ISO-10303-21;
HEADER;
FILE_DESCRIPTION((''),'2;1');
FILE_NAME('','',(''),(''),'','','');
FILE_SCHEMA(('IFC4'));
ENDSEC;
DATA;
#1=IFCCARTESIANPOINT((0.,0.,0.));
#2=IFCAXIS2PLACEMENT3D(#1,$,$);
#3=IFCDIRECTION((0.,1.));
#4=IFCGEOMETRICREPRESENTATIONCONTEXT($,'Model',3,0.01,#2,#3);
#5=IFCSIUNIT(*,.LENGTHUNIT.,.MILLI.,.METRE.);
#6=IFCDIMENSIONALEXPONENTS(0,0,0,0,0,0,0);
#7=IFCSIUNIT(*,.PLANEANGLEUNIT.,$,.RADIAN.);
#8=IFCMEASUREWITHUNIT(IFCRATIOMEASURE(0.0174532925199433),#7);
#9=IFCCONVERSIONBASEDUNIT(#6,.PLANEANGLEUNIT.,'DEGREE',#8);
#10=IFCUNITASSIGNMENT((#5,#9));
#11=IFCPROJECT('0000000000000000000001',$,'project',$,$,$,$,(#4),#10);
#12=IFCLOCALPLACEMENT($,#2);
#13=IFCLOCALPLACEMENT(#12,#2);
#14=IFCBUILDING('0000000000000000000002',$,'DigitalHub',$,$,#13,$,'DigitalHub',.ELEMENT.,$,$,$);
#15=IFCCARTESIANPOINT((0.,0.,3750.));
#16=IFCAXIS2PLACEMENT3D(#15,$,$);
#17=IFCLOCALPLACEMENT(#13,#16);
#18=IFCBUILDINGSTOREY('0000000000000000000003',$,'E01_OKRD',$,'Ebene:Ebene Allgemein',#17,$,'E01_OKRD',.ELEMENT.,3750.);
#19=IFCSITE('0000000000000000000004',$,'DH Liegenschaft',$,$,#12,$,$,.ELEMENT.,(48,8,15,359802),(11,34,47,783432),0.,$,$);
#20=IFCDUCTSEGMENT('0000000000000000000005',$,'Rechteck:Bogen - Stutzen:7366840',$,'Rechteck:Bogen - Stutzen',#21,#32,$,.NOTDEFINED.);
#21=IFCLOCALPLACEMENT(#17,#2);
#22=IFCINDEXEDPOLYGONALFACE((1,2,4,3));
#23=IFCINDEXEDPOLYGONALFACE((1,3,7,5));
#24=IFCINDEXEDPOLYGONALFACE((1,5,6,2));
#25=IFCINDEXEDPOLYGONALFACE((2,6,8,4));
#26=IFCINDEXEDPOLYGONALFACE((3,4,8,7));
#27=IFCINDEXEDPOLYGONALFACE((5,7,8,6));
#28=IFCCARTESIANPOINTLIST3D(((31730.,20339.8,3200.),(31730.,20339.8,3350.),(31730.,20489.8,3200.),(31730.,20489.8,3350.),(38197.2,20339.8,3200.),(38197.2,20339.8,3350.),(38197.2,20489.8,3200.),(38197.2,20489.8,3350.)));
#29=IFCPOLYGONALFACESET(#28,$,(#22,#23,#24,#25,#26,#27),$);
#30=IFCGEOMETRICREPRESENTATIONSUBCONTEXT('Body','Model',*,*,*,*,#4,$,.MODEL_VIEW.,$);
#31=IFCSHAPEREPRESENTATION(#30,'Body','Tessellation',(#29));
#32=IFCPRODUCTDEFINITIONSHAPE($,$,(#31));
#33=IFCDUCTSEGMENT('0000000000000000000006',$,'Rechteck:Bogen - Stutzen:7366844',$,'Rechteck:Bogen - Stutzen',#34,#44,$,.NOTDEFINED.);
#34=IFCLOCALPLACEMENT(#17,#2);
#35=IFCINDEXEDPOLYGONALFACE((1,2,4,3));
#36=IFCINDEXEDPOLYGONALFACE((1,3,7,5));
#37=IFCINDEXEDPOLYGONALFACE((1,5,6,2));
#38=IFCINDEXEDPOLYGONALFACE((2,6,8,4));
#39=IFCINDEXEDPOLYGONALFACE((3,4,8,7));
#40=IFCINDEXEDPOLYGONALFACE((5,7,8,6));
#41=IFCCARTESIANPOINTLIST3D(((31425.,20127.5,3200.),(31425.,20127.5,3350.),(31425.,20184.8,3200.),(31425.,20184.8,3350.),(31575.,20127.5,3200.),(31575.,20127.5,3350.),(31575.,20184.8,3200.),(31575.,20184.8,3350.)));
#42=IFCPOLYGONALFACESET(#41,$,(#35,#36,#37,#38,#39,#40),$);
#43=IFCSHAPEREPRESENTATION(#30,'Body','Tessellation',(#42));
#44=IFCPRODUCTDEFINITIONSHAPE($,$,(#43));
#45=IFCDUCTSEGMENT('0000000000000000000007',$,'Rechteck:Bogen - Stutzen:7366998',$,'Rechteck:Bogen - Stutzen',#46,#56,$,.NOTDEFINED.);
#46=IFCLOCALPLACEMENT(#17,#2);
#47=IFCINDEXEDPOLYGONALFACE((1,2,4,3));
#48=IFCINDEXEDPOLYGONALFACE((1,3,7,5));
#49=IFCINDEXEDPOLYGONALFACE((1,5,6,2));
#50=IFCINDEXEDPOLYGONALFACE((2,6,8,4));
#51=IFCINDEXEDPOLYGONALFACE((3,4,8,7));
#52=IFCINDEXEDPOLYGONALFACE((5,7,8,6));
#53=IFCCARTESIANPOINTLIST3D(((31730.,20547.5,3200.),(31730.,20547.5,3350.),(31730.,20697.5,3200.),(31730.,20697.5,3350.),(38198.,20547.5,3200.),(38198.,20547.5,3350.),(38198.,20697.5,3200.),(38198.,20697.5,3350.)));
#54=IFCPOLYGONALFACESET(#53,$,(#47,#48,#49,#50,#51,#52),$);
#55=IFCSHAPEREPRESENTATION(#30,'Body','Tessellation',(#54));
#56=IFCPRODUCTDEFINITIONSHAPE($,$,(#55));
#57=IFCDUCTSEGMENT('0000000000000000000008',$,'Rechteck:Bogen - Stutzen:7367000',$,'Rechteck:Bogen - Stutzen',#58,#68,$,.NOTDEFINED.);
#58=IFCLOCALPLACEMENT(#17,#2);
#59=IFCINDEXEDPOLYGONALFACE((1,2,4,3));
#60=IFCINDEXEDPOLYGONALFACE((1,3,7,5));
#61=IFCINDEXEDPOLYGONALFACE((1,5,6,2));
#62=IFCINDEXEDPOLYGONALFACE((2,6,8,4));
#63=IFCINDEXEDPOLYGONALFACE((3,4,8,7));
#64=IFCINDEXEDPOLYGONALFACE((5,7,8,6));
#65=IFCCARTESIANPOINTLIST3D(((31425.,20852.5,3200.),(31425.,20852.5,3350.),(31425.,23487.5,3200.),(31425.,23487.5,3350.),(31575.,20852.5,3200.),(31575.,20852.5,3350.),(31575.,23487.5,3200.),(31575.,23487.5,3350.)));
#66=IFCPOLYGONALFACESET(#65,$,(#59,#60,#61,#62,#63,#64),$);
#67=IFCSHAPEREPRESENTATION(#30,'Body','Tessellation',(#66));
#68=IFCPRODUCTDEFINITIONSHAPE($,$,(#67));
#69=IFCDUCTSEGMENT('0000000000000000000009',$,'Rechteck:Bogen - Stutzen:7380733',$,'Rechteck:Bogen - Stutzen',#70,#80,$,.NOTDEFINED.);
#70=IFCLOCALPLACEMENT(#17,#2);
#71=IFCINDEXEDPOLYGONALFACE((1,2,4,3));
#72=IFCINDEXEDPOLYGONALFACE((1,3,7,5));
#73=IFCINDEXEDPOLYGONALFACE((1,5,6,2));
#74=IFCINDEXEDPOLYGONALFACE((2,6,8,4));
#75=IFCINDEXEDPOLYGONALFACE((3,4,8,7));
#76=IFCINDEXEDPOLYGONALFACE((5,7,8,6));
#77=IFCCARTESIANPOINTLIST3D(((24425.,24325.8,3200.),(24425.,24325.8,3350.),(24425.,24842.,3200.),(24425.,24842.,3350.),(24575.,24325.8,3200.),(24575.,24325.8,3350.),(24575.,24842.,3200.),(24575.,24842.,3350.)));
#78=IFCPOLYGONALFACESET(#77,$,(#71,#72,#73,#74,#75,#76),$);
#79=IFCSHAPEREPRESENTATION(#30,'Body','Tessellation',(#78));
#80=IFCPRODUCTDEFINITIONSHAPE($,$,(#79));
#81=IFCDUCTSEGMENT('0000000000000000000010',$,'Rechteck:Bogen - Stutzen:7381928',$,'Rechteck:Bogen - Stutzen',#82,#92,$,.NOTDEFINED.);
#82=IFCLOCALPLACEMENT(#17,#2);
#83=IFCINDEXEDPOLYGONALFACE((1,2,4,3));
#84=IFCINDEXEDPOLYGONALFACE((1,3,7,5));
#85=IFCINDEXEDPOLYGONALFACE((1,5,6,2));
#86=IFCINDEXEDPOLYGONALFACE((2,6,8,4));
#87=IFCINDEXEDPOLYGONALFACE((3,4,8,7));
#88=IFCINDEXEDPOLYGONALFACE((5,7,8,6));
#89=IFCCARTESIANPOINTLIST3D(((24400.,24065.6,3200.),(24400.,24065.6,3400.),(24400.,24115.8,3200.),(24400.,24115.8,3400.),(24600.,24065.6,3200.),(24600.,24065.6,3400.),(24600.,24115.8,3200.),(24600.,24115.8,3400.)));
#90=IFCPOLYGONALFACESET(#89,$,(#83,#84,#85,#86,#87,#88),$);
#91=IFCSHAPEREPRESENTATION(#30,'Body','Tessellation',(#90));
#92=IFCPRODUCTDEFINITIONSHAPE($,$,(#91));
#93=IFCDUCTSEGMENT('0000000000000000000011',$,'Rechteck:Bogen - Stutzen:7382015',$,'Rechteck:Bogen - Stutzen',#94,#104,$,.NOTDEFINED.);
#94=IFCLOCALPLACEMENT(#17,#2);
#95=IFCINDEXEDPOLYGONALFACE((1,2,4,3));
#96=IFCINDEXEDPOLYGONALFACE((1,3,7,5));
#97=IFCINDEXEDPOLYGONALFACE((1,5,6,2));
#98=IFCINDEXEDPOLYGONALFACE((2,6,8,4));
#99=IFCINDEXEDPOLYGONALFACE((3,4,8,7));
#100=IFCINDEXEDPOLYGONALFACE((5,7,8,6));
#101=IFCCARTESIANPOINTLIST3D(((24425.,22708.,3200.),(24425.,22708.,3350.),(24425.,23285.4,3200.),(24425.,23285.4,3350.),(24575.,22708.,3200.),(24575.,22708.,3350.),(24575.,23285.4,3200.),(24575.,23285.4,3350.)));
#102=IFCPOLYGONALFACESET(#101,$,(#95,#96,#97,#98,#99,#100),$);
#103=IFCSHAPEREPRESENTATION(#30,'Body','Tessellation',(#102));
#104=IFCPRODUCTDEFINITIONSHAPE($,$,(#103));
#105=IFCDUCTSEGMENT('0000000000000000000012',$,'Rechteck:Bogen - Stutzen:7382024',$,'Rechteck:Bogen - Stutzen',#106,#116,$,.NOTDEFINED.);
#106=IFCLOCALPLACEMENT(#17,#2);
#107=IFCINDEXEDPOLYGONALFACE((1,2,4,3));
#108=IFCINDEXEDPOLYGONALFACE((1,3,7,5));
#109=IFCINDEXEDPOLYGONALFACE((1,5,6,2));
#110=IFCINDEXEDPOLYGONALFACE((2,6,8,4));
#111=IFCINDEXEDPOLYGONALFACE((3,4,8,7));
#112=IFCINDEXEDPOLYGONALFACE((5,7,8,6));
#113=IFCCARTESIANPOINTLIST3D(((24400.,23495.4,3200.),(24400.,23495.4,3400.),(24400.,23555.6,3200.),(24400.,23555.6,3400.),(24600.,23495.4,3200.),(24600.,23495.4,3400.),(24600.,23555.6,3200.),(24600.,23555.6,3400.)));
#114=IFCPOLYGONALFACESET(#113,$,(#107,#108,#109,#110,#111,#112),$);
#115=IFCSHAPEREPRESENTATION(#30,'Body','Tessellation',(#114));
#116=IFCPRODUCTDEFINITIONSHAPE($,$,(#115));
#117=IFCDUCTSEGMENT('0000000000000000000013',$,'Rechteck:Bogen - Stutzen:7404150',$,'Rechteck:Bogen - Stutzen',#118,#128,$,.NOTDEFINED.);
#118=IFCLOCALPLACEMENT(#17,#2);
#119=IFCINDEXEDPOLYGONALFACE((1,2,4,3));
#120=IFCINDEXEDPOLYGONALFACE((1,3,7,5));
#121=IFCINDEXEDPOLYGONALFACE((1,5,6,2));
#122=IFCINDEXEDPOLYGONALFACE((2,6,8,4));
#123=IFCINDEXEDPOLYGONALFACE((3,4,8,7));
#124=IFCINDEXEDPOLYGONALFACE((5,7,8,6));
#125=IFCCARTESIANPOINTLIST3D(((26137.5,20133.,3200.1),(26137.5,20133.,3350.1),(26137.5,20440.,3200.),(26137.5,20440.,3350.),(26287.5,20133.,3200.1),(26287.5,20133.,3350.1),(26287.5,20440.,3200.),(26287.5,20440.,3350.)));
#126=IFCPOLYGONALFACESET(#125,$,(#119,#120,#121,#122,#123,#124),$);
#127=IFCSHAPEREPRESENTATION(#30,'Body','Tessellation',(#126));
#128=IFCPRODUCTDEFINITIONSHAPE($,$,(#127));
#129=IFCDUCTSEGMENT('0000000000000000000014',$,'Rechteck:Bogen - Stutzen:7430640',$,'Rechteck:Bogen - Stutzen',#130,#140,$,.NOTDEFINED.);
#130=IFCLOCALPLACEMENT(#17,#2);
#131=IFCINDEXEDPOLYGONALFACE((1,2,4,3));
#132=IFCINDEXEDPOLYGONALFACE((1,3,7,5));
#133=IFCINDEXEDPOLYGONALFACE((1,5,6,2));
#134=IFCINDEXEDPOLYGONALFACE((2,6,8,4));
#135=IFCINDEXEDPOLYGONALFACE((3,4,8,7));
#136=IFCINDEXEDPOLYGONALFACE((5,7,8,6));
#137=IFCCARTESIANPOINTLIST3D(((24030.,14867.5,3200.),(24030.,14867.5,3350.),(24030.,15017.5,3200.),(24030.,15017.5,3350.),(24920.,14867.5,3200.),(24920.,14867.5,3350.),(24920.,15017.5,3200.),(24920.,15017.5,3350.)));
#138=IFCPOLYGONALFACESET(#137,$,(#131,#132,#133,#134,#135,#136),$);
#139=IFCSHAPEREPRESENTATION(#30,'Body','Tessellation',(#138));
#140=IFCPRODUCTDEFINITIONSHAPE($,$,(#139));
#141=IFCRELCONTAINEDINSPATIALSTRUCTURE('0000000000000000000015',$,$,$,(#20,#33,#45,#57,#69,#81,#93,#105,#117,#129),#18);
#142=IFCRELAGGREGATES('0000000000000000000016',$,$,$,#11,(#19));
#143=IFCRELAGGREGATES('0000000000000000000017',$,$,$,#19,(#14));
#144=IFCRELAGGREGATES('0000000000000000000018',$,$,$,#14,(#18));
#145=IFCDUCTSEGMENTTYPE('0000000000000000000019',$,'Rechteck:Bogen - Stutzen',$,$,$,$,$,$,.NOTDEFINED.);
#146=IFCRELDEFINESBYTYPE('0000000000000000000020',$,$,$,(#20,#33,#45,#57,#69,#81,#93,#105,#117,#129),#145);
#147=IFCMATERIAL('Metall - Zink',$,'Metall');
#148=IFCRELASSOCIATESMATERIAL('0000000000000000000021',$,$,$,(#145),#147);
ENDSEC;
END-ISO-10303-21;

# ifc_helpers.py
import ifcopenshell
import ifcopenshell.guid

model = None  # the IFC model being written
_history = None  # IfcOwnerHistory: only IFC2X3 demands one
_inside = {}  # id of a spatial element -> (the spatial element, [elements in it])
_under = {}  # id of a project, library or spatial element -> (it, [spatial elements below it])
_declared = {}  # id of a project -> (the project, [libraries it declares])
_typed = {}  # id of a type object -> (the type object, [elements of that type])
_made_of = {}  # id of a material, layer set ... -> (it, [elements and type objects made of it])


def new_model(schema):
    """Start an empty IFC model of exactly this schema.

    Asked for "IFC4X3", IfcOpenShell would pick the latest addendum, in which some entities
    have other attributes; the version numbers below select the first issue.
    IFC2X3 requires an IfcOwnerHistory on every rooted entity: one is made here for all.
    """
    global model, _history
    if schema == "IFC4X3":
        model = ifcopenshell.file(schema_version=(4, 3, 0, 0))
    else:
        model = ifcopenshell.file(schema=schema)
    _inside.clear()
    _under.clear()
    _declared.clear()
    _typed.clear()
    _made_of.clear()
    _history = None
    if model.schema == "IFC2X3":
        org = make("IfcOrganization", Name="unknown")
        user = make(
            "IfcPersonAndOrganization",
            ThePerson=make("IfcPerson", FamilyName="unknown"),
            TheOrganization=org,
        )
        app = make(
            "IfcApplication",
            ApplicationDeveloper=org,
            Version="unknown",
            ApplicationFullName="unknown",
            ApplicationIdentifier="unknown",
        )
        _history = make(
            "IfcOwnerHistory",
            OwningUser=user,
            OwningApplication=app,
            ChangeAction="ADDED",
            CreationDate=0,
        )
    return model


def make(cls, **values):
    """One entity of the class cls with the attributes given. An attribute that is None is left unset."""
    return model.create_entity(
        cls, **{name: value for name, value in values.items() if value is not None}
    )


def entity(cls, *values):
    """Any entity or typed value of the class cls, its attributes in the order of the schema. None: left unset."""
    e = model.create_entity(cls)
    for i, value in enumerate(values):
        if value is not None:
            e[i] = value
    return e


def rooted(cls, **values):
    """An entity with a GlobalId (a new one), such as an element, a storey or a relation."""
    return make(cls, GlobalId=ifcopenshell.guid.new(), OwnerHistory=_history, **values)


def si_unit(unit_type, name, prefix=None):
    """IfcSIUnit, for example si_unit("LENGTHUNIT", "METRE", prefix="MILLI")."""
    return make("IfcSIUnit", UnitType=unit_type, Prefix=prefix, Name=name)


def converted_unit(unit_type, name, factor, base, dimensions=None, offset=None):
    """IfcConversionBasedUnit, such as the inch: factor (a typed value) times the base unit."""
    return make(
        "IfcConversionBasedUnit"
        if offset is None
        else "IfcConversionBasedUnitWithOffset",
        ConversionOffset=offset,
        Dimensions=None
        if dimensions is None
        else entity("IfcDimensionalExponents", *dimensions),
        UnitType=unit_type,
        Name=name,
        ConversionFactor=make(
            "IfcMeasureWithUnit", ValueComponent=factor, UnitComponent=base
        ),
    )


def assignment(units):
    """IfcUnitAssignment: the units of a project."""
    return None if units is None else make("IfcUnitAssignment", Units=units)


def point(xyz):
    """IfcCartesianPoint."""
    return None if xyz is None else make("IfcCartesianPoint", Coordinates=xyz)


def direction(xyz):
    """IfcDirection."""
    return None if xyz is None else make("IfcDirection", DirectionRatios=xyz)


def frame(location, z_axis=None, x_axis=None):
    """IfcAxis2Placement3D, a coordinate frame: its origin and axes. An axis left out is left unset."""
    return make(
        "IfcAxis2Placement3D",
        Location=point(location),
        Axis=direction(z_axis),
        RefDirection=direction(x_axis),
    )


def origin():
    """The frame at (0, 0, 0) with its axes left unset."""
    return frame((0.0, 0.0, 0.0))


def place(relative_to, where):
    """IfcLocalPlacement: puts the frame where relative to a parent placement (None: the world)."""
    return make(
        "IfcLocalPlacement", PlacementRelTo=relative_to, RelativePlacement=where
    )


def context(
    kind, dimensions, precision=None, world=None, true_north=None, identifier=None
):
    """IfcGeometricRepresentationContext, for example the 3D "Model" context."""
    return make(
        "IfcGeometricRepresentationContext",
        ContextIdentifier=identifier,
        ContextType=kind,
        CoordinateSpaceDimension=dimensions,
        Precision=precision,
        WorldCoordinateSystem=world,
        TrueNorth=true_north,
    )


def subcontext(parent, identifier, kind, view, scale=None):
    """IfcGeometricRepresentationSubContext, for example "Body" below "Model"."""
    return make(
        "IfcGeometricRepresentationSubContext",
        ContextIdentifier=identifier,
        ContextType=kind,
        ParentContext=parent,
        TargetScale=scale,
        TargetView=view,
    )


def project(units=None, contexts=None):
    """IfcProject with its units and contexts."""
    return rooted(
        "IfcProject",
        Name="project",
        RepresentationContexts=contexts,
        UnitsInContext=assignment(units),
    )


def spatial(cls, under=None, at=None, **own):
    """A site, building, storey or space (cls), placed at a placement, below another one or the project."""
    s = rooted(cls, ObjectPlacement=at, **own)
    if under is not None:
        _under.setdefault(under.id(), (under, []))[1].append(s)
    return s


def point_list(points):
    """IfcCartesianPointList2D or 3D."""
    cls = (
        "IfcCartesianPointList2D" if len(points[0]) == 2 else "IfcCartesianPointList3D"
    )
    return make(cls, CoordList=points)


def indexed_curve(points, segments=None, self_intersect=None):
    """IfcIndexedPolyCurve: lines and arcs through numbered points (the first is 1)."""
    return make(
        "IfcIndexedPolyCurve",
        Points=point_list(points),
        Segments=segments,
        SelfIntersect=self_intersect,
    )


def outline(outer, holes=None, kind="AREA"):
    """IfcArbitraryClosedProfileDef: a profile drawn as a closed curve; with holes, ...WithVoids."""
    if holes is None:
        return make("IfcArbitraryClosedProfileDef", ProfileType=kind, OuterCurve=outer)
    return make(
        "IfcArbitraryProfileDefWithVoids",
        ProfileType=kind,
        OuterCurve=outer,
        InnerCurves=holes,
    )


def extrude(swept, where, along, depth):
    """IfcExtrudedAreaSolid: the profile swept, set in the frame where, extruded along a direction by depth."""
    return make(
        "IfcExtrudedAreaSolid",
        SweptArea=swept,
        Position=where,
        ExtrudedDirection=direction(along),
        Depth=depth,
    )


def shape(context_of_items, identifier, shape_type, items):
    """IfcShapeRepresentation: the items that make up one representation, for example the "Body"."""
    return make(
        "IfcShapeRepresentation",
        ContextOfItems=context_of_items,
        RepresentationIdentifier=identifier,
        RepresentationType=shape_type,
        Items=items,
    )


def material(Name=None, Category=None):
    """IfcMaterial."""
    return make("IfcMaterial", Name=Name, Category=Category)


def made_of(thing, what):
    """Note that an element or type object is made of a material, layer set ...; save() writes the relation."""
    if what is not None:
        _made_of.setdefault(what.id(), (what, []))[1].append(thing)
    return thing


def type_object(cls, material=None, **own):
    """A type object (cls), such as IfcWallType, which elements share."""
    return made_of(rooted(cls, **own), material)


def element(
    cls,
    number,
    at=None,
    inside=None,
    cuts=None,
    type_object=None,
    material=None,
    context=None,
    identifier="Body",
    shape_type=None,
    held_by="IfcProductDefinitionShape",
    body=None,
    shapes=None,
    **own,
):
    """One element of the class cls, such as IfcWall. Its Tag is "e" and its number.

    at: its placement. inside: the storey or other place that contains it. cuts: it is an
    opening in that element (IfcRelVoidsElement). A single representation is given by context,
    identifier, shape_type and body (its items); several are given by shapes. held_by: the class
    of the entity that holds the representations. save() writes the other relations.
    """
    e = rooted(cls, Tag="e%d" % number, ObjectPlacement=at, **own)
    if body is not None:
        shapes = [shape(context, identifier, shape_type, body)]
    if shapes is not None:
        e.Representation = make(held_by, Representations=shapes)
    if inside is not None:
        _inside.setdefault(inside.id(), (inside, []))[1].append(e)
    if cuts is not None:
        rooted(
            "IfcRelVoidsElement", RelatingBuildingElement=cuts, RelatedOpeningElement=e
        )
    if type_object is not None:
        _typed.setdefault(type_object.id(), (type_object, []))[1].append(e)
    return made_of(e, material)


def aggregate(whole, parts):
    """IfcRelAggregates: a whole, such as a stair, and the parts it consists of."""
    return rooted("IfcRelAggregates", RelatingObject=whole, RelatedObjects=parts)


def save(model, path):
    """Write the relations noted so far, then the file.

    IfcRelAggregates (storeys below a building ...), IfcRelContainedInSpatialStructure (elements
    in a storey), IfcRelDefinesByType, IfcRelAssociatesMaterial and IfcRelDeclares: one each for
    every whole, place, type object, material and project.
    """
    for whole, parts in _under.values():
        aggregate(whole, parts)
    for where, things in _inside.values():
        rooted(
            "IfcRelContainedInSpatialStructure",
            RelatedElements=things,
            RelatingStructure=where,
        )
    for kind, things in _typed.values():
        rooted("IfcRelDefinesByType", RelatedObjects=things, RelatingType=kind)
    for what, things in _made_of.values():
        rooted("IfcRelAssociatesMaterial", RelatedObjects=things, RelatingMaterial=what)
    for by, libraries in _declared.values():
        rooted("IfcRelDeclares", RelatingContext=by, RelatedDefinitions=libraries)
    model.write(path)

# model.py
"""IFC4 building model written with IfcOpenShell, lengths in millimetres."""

from ifc_helpers import new_model, entity, si_unit, converted_unit, direction, frame, origin, place, context, subcontext, project, spatial, indexed_curve, outline, extrude, material, type_object, element, save


model = new_model("IFC4")

# Units and contexts
model_context = context("Model", 3, precision=0.01, world=origin(), true_north=direction((0.0, 1.0)))
body_context = subcontext(model_context, "Body", "Model", "MODEL_VIEW")
ifc_project = project(units=[si_unit("LENGTHUNIT", "METRE", prefix="MILLI"), converted_unit("PLANEANGLEUNIT", "DEGREE", entity("IfcRatioMeasure", 0.0174532925199433), si_unit("PLANEANGLEUNIT", "RADIAN"), dimensions=[0, 0, 0, 0, 0, 0, 0])], contexts=[model_context])

# Site, building, storey
site_placement = place(None, origin())
site = spatial("IfcSite", under=ifc_project, at=site_placement, Name="DH Liegenschaft", CompositionType="ELEMENT", RefLatitude=(48, 8, 15, 359802), RefLongitude=(11, 34, 47, 783432), RefElevation=0.0)
building_placement = place(site_placement, origin())
building = spatial("IfcBuilding", under=site, at=building_placement, Name="DigitalHub", LongName="DigitalHub", CompositionType="ELEMENT")
storey_placement = place(building_placement, frame((0.0, 0.0, 3750.0)))
storey = spatial("IfcBuildingStorey", under=building, at=storey_placement, Name="E01_OKRD", ObjectType="Ebene:Ebene Allgemein", LongName="E01_OKRD", CompositionType="ELEMENT", Elevation=3750.0)

# Duct segments
ifc_material_1 = material(Name="Metall - Zink", Category="Metall")
duct_segment_type_1 = type_object("IfcDuctSegmentType", Name="Rechteck:Bogen - Stutzen", PredefinedType="NOTDEFINED", material=ifc_material_1)
duct_segment_1_placement = place(storey_placement, frame((31730.0, 20339.8, 3200.0)))
element("IfcDuctSegment", 1, at=duct_segment_1_placement, inside=storey, type_object=duct_segment_type_1, Name="Rechteck:Bogen - Stutzen:7366840", ObjectType="Rechteck:Bogen - Stutzen", PredefinedType="NOTDEFINED", context=body_context, shape_type="SweptSolid", body=[
    extrude(outline(indexed_curve([(-3233.6, -75.0), (3233.6, -75.0), (3233.6, 75.0), (-3233.6, 75.0), (-3233.6, -75.0)], self_intersect=False)), frame((3233.6, 75.0, 0.0)), (0.0, 0.0, 1.0), 150.0),
])
duct_segment_2_placement = place(storey_placement, frame((31425.0, 20127.5, 3200.0)))
element("IfcDuctSegment", 2, at=duct_segment_2_placement, inside=storey, type_object=duct_segment_type_1, Name="Rechteck:Bogen - Stutzen:7366844", ObjectType="Rechteck:Bogen - Stutzen", PredefinedType="NOTDEFINED", context=body_context, shape_type="SweptSolid", body=[
    extrude(outline(indexed_curve([(-28.7, -75.0), (28.7, -75.0), (28.7, 75.0), (-28.7, 75.0), (-28.7, -75.0)], self_intersect=False)), frame((75.0, 28.7, 0.0), z_axis=(0.0, 0.0, 1.0), x_axis=(0.0, 1.0, 0.0)), (0.0, 0.0, 1.0), 150.0),
])
duct_segment_3_placement = place(storey_placement, frame((31730.0, 20547.5, 3200.0)))
element("IfcDuctSegment", 3, at=duct_segment_3_placement, inside=storey, type_object=duct_segment_type_1, Name="Rechteck:Bogen - Stutzen:7366998", ObjectType="Rechteck:Bogen - Stutzen", PredefinedType="NOTDEFINED", context=body_context, shape_type="SweptSolid", body=[
    extrude(outline(indexed_curve([(-3234.0, -75.0), (3234.0, -75.0), (3234.0, 75.0), (-3234.0, 75.0), (-3234.0, -75.0)], self_intersect=False)), frame((3234.0, 75.0, 0.0), z_axis=(0.0, 0.0, 1.0), x_axis=(-1.0, 0.0, 0.0)), (0.0, 0.0, 1.0), 150.0),
])
duct_segment_4_placement = place(storey_placement, frame((31425.0, 20852.5, 3200.0)))
element("IfcDuctSegment", 4, at=duct_segment_4_placement, inside=storey, type_object=duct_segment_type_1, Name="Rechteck:Bogen - Stutzen:7367000", ObjectType="Rechteck:Bogen - Stutzen", PredefinedType="NOTDEFINED", context=body_context, shape_type="SweptSolid", body=[
    extrude(outline(indexed_curve([(-1317.5, -75.0), (1317.5, -75.0), (1317.5, 75.0), (-1317.5, 75.0), (-1317.5, -75.0)], self_intersect=False)), frame((75.0, 1317.5, 0.0), z_axis=(0.0, 0.0, 1.0), x_axis=(0.0, 1.0, 0.0)), (0.0, 0.0, 1.0), 150.0),
])
duct_segment_5_placement = place(storey_placement, frame((24425.0, 24325.8, 3200.0)))
element("IfcDuctSegment", 5, at=duct_segment_5_placement, inside=storey, type_object=duct_segment_type_1, Name="Rechteck:Bogen - Stutzen:7380733", ObjectType="Rechteck:Bogen - Stutzen", PredefinedType="NOTDEFINED", context=body_context, shape_type="SweptSolid", body=[
    extrude(outline(indexed_curve([(-258.1, -75.0), (258.1, -75.0), (258.1, 75.0), (-258.1, 75.0), (-258.1, -75.0)], self_intersect=False)), frame((75.0, 258.1, 0.0), z_axis=(0.0, 0.0, 1.0), x_axis=(0.0, -1.0, 0.0)), (0.0, 0.0, 1.0), 150.0),
])
duct_segment_6_placement = place(storey_placement, frame((24400.0, 24065.6, 3200.0)))
element("IfcDuctSegment", 6, at=duct_segment_6_placement, inside=storey, type_object=duct_segment_type_1, Name="Rechteck:Bogen - Stutzen:7381928", ObjectType="Rechteck:Bogen - Stutzen", PredefinedType="NOTDEFINED", context=body_context, shape_type="SweptSolid", body=[
    extrude(outline(indexed_curve([(-25.1, -100.0), (25.1, -100.0), (25.1, 100.0), (-25.1, 100.0), (-25.1, -100.0)], self_intersect=False)), frame((100.0, 25.1, 0.0), z_axis=(0.0, 0.0, 1.0), x_axis=(0.0, 1.0, 0.0)), (0.0, 0.0, 1.0), 200.0),
])
duct_segment_7_placement = place(storey_placement, frame((24425.0, 22708.0, 3200.0)))
element("IfcDuctSegment", 7, at=duct_segment_7_placement, inside=storey, type_object=duct_segment_type_1, Name="Rechteck:Bogen - Stutzen:7382015", ObjectType="Rechteck:Bogen - Stutzen", PredefinedType="NOTDEFINED", context=body_context, shape_type="SweptSolid", body=[
    extrude(outline(indexed_curve([(-288.7, -75.0), (288.7, -75.0), (288.7, 75.0), (-288.7, 75.0), (-288.7, -75.0)], self_intersect=False)), frame((75.0, 288.7, 0.0), z_axis=(0.0, 0.0, 1.0), x_axis=(0.0, -1.0, 0.0)), (0.0, 0.0, 1.0), 150.0),
])
duct_segment_8_placement = place(storey_placement, frame((24400.0, 23495.4, 3200.0)))
element("IfcDuctSegment", 8, at=duct_segment_8_placement, inside=storey, type_object=duct_segment_type_1, Name="Rechteck:Bogen - Stutzen:7382024", ObjectType="Rechteck:Bogen - Stutzen", PredefinedType="NOTDEFINED", context=body_context, shape_type="SweptSolid", body=[
    extrude(outline(indexed_curve([(-30.1, -100.0), (30.1, -100.0), (30.1, 100.0), (-30.1, 100.0), (-30.1, -100.0)], self_intersect=False)), frame((100.0, 30.1, 0.0), z_axis=(0.0, 0.0, 1.0), x_axis=(0.0, -1.0, 0.0)), (0.0, 0.0, 1.0), 200.0),
])
duct_segment_9_placement = place(storey_placement, frame((26137.5, 20133.0, 3200.0)))
element("IfcDuctSegment", 9, at=duct_segment_9_placement, inside=storey, type_object=duct_segment_type_1, Name="Rechteck:Bogen - Stutzen:7404150", ObjectType="Rechteck:Bogen - Stutzen", PredefinedType="NOTDEFINED", context=body_context, shape_type="SweptSolid", body=[
    extrude(outline(indexed_curve([(-153.5, -75.0), (153.5, -75.0), (153.5, 75.0), (-153.5, 75.0), (-153.5, -75.0)], self_intersect=False)), frame((75.0, 153.5, 0.0), z_axis=(0.0, 0.000174, 1.0), x_axis=(0.0, 1.0, -0.000174)), (0.0, 0.0, 1.0), 150.0),
])
duct_segment_10_placement = place(storey_placement, frame((24030.0, 14867.5, 3200.0)))
element("IfcDuctSegment", 10, at=duct_segment_10_placement, inside=storey, type_object=duct_segment_type_1, Name="Rechteck:Bogen - Stutzen:7430640", ObjectType="Rechteck:Bogen - Stutzen", PredefinedType="NOTDEFINED", context=body_context, shape_type="SweptSolid", body=[
    extrude(outline(indexed_curve([(-445.0, -75.0), (445.0, -75.0), (445.0, 75.0), (-445.0, 75.0), (-445.0, -75.0)], self_intersect=False)), frame((445.0, 75.0, 0.0), z_axis=(-0.000017, 0.0, 1.0), x_axis=(-1.0, 0.0, -0.000017)), (0.0, 0.0, 1.0), 150.0),
])

save(model, "model.ifc")
